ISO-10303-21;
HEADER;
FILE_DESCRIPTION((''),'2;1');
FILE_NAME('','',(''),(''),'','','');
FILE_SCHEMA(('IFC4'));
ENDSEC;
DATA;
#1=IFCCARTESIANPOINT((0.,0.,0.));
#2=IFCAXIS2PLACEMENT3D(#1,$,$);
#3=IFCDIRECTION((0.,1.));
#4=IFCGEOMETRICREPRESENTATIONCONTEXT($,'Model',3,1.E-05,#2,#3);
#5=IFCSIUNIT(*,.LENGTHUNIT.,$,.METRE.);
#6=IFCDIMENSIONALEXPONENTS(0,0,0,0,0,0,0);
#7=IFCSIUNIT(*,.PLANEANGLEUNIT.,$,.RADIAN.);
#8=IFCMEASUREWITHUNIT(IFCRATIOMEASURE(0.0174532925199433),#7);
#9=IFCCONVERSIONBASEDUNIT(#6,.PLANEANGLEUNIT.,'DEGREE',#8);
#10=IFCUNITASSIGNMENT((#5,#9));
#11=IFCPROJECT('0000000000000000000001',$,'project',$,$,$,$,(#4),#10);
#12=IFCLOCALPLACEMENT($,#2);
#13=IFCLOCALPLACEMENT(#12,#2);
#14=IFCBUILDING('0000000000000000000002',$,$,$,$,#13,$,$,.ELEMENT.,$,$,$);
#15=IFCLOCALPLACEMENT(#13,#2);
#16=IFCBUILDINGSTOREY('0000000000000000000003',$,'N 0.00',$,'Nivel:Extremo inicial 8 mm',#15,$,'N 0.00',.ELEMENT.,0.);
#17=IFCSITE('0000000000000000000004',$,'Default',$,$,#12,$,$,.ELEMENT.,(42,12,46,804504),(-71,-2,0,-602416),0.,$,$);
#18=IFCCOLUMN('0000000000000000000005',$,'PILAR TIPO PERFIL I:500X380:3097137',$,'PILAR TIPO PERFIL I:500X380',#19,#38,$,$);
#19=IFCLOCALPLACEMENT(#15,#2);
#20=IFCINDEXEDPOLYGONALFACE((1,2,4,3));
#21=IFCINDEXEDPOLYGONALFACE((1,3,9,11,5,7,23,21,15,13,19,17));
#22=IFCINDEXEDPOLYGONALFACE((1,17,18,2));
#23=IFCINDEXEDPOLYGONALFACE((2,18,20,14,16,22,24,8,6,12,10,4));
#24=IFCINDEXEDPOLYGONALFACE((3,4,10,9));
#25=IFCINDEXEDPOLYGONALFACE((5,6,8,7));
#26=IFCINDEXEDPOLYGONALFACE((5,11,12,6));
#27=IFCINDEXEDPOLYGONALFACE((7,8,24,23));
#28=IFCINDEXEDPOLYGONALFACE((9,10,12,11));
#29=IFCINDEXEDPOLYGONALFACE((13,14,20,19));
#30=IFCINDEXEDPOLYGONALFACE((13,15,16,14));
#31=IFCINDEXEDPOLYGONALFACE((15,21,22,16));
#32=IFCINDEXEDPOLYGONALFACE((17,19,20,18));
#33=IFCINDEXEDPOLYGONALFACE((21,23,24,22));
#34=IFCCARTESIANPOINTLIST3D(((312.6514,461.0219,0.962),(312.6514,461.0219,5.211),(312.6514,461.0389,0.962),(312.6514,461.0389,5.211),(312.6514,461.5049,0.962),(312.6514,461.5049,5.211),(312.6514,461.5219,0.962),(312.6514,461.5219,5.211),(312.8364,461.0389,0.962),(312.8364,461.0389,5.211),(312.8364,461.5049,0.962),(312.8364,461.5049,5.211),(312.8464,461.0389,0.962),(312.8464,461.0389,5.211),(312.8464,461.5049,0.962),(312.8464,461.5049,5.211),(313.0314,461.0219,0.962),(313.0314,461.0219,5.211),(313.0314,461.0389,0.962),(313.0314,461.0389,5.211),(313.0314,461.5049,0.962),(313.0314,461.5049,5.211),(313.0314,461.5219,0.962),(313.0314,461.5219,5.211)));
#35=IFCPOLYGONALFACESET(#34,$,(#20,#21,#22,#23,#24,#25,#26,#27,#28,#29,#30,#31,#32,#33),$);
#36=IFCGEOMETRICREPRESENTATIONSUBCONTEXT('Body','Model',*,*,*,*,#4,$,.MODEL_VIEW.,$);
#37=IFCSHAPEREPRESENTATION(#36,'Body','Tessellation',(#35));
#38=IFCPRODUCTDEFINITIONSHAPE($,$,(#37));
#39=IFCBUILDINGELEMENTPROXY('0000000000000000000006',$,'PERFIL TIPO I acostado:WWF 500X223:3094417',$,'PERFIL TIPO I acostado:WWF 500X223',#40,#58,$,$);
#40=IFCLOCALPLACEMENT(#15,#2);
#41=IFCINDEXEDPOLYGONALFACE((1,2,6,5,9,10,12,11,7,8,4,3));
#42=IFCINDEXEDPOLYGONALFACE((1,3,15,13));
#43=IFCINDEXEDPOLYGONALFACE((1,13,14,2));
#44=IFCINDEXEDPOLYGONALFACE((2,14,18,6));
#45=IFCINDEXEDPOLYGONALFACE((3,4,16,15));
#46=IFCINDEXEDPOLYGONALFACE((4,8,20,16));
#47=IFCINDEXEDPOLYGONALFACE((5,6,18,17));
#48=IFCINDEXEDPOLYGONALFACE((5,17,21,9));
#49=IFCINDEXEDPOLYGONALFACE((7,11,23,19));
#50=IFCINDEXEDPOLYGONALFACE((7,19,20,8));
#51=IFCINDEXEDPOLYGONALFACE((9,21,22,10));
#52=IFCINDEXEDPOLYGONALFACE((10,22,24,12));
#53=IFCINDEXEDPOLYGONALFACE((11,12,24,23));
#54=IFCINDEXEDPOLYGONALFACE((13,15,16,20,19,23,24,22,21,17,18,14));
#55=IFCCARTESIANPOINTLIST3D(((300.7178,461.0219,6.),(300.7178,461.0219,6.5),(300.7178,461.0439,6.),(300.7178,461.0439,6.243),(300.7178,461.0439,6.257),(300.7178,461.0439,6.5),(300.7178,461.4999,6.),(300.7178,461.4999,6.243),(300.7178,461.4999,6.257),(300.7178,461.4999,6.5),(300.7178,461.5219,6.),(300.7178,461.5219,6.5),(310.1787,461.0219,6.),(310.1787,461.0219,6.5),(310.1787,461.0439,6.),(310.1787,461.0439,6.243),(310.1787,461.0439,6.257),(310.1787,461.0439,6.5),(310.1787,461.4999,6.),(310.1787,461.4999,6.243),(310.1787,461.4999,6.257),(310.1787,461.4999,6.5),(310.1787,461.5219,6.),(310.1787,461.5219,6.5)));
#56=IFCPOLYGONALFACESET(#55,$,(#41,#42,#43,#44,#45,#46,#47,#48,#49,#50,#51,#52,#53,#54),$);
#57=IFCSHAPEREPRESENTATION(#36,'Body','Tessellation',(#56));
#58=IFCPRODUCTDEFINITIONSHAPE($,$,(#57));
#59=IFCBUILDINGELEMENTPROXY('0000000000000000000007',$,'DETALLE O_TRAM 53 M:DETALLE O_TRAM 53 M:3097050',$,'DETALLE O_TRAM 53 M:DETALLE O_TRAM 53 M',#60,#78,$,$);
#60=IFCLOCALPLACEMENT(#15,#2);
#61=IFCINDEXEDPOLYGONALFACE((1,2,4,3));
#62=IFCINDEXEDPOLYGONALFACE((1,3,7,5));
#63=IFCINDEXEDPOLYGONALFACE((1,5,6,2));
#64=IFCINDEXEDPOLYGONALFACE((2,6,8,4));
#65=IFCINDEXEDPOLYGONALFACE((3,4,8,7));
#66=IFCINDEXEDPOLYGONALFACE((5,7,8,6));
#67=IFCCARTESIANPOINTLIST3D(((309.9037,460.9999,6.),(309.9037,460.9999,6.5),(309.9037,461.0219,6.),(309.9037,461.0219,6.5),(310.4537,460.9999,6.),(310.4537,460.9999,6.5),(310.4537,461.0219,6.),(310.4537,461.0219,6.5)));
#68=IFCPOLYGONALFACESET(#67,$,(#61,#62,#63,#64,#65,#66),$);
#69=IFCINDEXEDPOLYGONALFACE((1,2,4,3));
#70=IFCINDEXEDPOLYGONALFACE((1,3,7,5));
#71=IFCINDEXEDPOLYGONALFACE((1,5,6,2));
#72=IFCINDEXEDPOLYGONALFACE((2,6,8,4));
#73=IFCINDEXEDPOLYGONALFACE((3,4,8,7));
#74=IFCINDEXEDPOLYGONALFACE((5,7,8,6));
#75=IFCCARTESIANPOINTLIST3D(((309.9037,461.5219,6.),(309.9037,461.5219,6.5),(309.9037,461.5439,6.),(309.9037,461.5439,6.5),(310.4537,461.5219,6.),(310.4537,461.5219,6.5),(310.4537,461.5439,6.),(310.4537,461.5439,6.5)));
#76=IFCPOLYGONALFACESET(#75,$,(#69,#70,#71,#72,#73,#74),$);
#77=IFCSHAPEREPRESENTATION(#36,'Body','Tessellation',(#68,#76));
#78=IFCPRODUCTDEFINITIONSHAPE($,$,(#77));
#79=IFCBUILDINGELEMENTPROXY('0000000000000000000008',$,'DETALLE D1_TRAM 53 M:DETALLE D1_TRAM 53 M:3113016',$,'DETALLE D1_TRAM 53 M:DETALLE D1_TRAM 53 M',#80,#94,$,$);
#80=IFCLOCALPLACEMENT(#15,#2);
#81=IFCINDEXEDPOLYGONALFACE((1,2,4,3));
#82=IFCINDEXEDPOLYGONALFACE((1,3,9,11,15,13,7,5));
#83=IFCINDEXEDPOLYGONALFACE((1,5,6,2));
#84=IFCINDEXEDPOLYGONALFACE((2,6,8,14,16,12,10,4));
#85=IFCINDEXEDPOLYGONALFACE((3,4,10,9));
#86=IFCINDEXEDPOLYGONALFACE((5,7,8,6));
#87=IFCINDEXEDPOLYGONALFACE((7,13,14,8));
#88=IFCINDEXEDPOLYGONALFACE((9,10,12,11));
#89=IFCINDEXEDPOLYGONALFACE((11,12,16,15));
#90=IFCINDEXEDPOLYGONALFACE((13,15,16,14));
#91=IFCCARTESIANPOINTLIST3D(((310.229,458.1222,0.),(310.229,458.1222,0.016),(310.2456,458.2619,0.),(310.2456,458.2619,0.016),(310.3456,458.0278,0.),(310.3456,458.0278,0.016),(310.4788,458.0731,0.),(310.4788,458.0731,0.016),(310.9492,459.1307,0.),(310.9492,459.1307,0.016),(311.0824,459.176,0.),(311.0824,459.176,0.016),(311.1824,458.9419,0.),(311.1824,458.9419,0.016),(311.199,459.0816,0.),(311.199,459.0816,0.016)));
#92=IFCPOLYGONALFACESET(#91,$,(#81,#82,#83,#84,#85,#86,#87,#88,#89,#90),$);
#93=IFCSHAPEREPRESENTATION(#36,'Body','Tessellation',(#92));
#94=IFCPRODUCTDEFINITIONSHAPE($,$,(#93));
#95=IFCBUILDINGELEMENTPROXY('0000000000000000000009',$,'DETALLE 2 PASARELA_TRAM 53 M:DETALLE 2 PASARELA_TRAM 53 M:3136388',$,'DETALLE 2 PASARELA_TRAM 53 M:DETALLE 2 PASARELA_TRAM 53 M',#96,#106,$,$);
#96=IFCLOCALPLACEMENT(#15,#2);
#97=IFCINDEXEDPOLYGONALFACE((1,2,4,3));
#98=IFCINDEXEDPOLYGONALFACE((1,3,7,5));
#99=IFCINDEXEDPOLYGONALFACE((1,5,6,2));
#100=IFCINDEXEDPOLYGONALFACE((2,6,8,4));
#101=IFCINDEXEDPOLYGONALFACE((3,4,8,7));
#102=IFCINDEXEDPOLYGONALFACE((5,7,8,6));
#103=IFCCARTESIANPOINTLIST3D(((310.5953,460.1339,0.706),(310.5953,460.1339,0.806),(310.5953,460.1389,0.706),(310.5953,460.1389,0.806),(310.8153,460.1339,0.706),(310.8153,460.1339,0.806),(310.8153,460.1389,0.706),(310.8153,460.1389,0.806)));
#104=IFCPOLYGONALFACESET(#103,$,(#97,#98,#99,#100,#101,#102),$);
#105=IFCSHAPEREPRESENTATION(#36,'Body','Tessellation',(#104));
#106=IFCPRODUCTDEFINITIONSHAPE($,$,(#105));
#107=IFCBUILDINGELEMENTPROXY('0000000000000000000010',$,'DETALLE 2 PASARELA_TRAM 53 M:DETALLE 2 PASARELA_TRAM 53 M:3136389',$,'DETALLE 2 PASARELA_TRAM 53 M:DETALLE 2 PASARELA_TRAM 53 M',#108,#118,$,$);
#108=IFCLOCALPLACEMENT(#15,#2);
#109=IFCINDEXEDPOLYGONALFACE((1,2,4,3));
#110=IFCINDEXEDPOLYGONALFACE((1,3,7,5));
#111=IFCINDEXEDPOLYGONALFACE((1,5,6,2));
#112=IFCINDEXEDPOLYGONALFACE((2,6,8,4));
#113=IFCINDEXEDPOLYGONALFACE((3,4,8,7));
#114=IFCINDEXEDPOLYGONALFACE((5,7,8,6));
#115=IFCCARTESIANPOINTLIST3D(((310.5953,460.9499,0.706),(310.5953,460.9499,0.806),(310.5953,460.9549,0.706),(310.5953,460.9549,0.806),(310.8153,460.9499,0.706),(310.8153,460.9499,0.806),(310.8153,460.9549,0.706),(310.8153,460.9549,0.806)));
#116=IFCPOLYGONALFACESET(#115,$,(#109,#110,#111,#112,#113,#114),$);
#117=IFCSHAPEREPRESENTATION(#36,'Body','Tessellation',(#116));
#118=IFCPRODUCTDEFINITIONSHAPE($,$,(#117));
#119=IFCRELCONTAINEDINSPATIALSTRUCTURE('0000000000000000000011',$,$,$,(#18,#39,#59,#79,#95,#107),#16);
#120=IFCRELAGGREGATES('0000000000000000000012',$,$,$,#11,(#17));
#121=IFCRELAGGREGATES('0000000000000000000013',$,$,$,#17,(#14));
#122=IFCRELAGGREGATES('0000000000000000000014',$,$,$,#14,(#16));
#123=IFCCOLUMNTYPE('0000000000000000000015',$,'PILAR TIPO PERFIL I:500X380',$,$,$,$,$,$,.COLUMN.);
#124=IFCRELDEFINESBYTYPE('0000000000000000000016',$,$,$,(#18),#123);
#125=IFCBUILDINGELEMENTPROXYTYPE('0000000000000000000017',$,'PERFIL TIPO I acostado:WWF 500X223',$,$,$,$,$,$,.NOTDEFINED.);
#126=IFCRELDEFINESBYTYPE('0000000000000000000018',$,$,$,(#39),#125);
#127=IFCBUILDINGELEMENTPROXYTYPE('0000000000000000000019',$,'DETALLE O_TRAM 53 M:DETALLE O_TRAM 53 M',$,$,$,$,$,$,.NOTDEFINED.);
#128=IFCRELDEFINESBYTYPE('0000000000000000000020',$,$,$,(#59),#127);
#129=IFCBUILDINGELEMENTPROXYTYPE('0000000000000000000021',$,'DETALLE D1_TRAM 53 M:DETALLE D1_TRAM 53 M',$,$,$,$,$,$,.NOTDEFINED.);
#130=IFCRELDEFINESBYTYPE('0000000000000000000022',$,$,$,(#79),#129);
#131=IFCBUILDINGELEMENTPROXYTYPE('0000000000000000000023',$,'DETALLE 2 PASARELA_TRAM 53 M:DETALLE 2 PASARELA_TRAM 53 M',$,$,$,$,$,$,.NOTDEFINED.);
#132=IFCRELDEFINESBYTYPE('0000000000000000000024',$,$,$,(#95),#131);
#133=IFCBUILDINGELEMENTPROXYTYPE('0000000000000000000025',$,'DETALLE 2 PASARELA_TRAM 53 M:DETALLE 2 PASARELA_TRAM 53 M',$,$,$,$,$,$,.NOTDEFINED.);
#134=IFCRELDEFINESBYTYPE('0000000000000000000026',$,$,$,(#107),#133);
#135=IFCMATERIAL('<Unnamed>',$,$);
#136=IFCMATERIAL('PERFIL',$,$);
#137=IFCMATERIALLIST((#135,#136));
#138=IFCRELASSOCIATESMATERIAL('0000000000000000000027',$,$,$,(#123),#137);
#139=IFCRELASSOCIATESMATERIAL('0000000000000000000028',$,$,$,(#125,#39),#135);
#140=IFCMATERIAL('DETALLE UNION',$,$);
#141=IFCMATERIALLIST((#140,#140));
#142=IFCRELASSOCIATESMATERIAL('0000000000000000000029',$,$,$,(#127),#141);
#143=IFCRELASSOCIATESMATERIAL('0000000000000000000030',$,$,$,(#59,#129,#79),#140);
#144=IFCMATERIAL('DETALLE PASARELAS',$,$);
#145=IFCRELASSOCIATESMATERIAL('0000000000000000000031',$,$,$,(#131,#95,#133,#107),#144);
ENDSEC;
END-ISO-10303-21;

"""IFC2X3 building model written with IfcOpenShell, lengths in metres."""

from ifc_helpers import new_model, entity, si_unit, converted_unit, direction, frame, frame_2d, origin, place, context, subcontext, project, spatial, polyline, rectangle, i_section, outline, extrude, source, transform, mapped, material, material_list, type_object, type_shapes, element, save


model = new_model("IFC2X3")

# Units and contexts
model_context = context("Model", 3, precision=1e-05, world=origin(), true_north=direction((0.0, 1.0)))
body_context = subcontext(model_context, "Body", "Model", "MODEL_VIEW")
ifc_project = project(units=[si_unit("LENGTHUNIT", "METRE"), converted_unit("PLANEANGLEUNIT", "DEGREE", entity("IfcRatioMeasure", 0.0174532925199433), si_unit("PLANEANGLEUNIT", "RADIAN"), dimensions=[0, 0, 0, 0, 0, 0, 0])], contexts=[model_context])

# Site, building, storey
site_placement = place(None, origin())
site = spatial("IfcSite", under=ifc_project, at=site_placement, Name="Default", CompositionType="ELEMENT", RefLatitude=(42, 12, 46, 804504), RefLongitude=(-71, -2, 0, -602416), RefElevation=0.0)
building_placement = place(site_placement, origin())
building = spatial("IfcBuilding", under=site, at=building_placement, CompositionType="ELEMENT")
storey_placement = place(building_placement, origin())
storey = spatial("IfcBuildingStorey", under=building, at=storey_placement, Name="N 0.00", ObjectType="Nivel:Extremo inicial 8 mm", LongName="N 0.00", CompositionType="ELEMENT", Elevation=0.0)

# Column
ifc_material_1 = material(Name="<Unnamed>")
ifc_material_2 = material(Name="PERFIL")
ifc_material_list_1 = material_list([ifc_material_1, ifc_material_2])
column_type = type_object("IfcColumnType", Name="PILAR TIPO PERFIL I:500X380", PredefinedType="COLUMN", material=ifc_material_list_1)
shared_shape_1 = source(origin(), body_context, "Body", "SweptSolid", [
    extrude(i_section(OverallWidth=0.38, OverallDepth=0.5, WebThickness=0.01, FlangeThickness=0.017, at=frame_2d((0.0, 0.0), x_axis=(1.0, 0.0))), frame((0.0, 0.0, 0.962), z_axis=(0.0, 0.0, 1.0), x_axis=(0.0, -1.0, 0.0)), (0.0, 0.0, 1.0), 4.249),
])
type_shapes(column_type, [shared_shape_1])
column_placement = place(storey_placement, frame((312.8414, 461.2719, 0.0), z_axis=(0.0, 0.0, 1.0), x_axis=(0.0, -1.0, 0.0)))
element("IfcColumn", 1, at=column_placement, inside=storey, type_object=column_type, Name="PILAR TIPO PERFIL I:500X380:3097137", ObjectType="PILAR TIPO PERFIL I:500X380", context=body_context, shape_type="MappedRepresentation", body=[
    mapped(shared_shape_1, transform((0.0, 0.0, 0.0), scale=1.0)),
])

# Building element proxies
ifc_material_3 = material(Name="DETALLE UNION")
building_element_proxy_type_1 = type_object("IfcBuildingElementProxyType", Name="PERFIL TIPO I acostado:WWF 500X223", PredefinedType="NOTDEFINED", material=ifc_material_1)
shared_shape_2 = source(origin(), body_context, "Body", "SweptSolid", [
    extrude(outline(polyline([(0.228, -0.25), (0.25, -0.25), (0.25, 0.25), (0.228, 0.25), (0.228, 0.007), (-0.228, 0.007), (-0.228, 0.25), (-0.25, 0.25), (-0.25, -0.25), (-0.228, -0.25), (-0.228, -0.007), (0.228, -0.007), (0.228, -0.25)])), frame((0.0, 0.0, 0.25), z_axis=(1.0, 0.0, 0.0), x_axis=(0.0, -1.0, 0.0)), (0.0, 0.0, 1.0), 9.461),
])
type_shapes(building_element_proxy_type_1, [shared_shape_2])
proxy_1_placement = place(storey_placement, frame((310.1787, 461.2719, 6.0), z_axis=(0.0, 0.0, 1.0), x_axis=(-1.0, 0.0, 0.0)))
element("IfcBuildingElementProxy", 2, at=proxy_1_placement, inside=storey, type_object=building_element_proxy_type_1, material=ifc_material_1, Name="PERFIL TIPO I acostado:WWF 500X223:3094417", ObjectType="PERFIL TIPO I acostado:WWF 500X223", context=body_context, shape_type="MappedRepresentation", body=[
    mapped(shared_shape_2, transform((0.0, 0.0, 0.0), scale=1.0)),
])
ifc_material_list_2 = material_list([ifc_material_3, ifc_material_3])
building_element_proxy_type_2 = type_object("IfcBuildingElementProxyType", Name="DETALLE O_TRAM 53 M:DETALLE O_TRAM 53 M", PredefinedType="NOTDEFINED", material=ifc_material_list_2)
shared_shape_3 = source(origin(), body_context, "Body", "SweptSolid", [
    extrude(rectangle(XDim=0.022, YDim=0.55, at=frame_2d((0.0, 0.0), x_axis=(1.0, 0.0))), frame((0.275, -0.011, 0.0), z_axis=(0.0, 0.0, 1.0), x_axis=(0.0, 1.0, 0.0)), (0.0, 0.0, 1.0), 0.5),
    extrude(rectangle(XDim=0.022, YDim=0.55, at=frame_2d((0.0, 0.0), x_axis=(1.0, 0.0))), frame((0.275, 0.511, 0.0), z_axis=(0.0, 0.0, 1.0), x_axis=(0.0, 1.0, 0.0)), (0.0, 0.0, 1.0), 0.5),
])
type_shapes(building_element_proxy_type_2, [shared_shape_3])
proxy_2_placement = place(storey_placement, frame((309.9037, 461.0219, 6.0)))
element("IfcBuildingElementProxy", 3, at=proxy_2_placement, inside=storey, type_object=building_element_proxy_type_2, material=ifc_material_3, Name="DETALLE O_TRAM 53 M:DETALLE O_TRAM 53 M:3097050", ObjectType="DETALLE O_TRAM 53 M:DETALLE O_TRAM 53 M", context=body_context, shape_type="MappedRepresentation", body=[
    mapped(shared_shape_3, transform((0.0, 0.0, 0.0), scale=1.0)),
])
building_element_proxy_type_3 = type_object("IfcBuildingElementProxyType", Name="DETALLE D1_TRAM 53 M:DETALLE D1_TRAM 53 M", PredefinedType="NOTDEFINED", material=ifc_material_3)
shared_shape_4 = source(origin(), body_context, "Body", "SweptSolid", [
    extrude(outline(polyline([(-0.075, -0.678), (0.075, -0.678), (0.15, -0.559), (0.15, 0.559), (0.075, 0.678), (-0.075, 0.678), (-0.15, 0.559), (-0.15, -0.559), (-0.075, -0.678)])), frame((0.0, 0.0, 0.0), z_axis=(0.0, 0.0, 1.0), x_axis=(-0.777146, 0.62932, 0.0)), (0.0, 0.0, 1.0), 0.016),
])
type_shapes(building_element_proxy_type_3, [shared_shape_4])
proxy_3_placement = place(storey_placement, frame((310.714, 458.6019, 0.0)))
element("IfcBuildingElementProxy", 4, at=proxy_3_placement, inside=storey, type_object=building_element_proxy_type_3, material=ifc_material_3, Name="DETALLE D1_TRAM 53 M:DETALLE D1_TRAM 53 M:3113016", ObjectType="DETALLE D1_TRAM 53 M:DETALLE D1_TRAM 53 M", context=body_context, shape_type="MappedRepresentation", body=[
    mapped(shared_shape_4, transform((0.0, 0.0, 0.0), scale=1.0)),
])
ifc_material_4 = material(Name="DETALLE PASARELAS")
building_element_proxy_type_4 = type_object("IfcBuildingElementProxyType", Name="DETALLE 2 PASARELA_TRAM 53 M:DETALLE 2 PASARELA_TRAM 53 M", PredefinedType="NOTDEFINED", material=ifc_material_4)
shared_shape_5 = source(origin(), body_context, "Body", "SweptSolid", [
    extrude(rectangle(XDim=0.22, YDim=0.005, at=frame_2d((0.0, 0.0), x_axis=(1.0, 0.0))), frame((0.11, 0.0475, 0.0), z_axis=(0.0, 0.0, 1.0), x_axis=(-1.0, 0.0, 0.0)), (0.0, 0.0, 1.0), 0.1),
])
type_shapes(building_element_proxy_type_4, [shared_shape_5])
proxy_4_placement = place(storey_placement, frame((310.5953, 460.0889, 0.706)))
element("IfcBuildingElementProxy", 5, at=proxy_4_placement, inside=storey, type_object=building_element_proxy_type_4, material=ifc_material_4, Name="DETALLE 2 PASARELA_TRAM 53 M:DETALLE 2 PASARELA_TRAM 53 M:3136388", ObjectType="DETALLE 2 PASARELA_TRAM 53 M:DETALLE 2 PASARELA_TRAM 53 M", context=body_context, shape_type="MappedRepresentation", body=[
    mapped(shared_shape_5, transform((0.0, 0.0, 0.0), scale=1.0)),
])
building_element_proxy_type_5 = type_object("IfcBuildingElementProxyType", Name="DETALLE 2 PASARELA_TRAM 53 M:DETALLE 2 PASARELA_TRAM 53 M", PredefinedType="NOTDEFINED", material=ifc_material_4)
shared_shape_6 = source(origin(), body_context, "Body", "SweptSolid", [
    extrude(rectangle(XDim=0.005, YDim=0.22, at=frame_2d((0.0, 0.0), x_axis=(1.0, 0.0))), frame((0.11, -0.0475, 0.0), z_axis=(0.0, 0.0, 1.0), x_axis=(0.0, 1.0, 0.0)), (0.0, 0.0, 1.0), 0.1),
])
type_shapes(building_element_proxy_type_5, [shared_shape_6])
proxy_5_placement = place(storey_placement, frame((310.5953, 460.9999, 0.706)))
element("IfcBuildingElementProxy", 6, at=proxy_5_placement, inside=storey, type_object=building_element_proxy_type_5, material=ifc_material_4, Name="DETALLE 2 PASARELA_TRAM 53 M:DETALLE 2 PASARELA_TRAM 53 M:3136389", ObjectType="DETALLE 2 PASARELA_TRAM 53 M:DETALLE 2 PASARELA_TRAM 53 M", context=body_context, shape_type="MappedRepresentation", body=[
    mapped(shared_shape_6, transform((0.0, 0.0, 0.0), scale=1.0)),
])

save(model, "model.ifc")
